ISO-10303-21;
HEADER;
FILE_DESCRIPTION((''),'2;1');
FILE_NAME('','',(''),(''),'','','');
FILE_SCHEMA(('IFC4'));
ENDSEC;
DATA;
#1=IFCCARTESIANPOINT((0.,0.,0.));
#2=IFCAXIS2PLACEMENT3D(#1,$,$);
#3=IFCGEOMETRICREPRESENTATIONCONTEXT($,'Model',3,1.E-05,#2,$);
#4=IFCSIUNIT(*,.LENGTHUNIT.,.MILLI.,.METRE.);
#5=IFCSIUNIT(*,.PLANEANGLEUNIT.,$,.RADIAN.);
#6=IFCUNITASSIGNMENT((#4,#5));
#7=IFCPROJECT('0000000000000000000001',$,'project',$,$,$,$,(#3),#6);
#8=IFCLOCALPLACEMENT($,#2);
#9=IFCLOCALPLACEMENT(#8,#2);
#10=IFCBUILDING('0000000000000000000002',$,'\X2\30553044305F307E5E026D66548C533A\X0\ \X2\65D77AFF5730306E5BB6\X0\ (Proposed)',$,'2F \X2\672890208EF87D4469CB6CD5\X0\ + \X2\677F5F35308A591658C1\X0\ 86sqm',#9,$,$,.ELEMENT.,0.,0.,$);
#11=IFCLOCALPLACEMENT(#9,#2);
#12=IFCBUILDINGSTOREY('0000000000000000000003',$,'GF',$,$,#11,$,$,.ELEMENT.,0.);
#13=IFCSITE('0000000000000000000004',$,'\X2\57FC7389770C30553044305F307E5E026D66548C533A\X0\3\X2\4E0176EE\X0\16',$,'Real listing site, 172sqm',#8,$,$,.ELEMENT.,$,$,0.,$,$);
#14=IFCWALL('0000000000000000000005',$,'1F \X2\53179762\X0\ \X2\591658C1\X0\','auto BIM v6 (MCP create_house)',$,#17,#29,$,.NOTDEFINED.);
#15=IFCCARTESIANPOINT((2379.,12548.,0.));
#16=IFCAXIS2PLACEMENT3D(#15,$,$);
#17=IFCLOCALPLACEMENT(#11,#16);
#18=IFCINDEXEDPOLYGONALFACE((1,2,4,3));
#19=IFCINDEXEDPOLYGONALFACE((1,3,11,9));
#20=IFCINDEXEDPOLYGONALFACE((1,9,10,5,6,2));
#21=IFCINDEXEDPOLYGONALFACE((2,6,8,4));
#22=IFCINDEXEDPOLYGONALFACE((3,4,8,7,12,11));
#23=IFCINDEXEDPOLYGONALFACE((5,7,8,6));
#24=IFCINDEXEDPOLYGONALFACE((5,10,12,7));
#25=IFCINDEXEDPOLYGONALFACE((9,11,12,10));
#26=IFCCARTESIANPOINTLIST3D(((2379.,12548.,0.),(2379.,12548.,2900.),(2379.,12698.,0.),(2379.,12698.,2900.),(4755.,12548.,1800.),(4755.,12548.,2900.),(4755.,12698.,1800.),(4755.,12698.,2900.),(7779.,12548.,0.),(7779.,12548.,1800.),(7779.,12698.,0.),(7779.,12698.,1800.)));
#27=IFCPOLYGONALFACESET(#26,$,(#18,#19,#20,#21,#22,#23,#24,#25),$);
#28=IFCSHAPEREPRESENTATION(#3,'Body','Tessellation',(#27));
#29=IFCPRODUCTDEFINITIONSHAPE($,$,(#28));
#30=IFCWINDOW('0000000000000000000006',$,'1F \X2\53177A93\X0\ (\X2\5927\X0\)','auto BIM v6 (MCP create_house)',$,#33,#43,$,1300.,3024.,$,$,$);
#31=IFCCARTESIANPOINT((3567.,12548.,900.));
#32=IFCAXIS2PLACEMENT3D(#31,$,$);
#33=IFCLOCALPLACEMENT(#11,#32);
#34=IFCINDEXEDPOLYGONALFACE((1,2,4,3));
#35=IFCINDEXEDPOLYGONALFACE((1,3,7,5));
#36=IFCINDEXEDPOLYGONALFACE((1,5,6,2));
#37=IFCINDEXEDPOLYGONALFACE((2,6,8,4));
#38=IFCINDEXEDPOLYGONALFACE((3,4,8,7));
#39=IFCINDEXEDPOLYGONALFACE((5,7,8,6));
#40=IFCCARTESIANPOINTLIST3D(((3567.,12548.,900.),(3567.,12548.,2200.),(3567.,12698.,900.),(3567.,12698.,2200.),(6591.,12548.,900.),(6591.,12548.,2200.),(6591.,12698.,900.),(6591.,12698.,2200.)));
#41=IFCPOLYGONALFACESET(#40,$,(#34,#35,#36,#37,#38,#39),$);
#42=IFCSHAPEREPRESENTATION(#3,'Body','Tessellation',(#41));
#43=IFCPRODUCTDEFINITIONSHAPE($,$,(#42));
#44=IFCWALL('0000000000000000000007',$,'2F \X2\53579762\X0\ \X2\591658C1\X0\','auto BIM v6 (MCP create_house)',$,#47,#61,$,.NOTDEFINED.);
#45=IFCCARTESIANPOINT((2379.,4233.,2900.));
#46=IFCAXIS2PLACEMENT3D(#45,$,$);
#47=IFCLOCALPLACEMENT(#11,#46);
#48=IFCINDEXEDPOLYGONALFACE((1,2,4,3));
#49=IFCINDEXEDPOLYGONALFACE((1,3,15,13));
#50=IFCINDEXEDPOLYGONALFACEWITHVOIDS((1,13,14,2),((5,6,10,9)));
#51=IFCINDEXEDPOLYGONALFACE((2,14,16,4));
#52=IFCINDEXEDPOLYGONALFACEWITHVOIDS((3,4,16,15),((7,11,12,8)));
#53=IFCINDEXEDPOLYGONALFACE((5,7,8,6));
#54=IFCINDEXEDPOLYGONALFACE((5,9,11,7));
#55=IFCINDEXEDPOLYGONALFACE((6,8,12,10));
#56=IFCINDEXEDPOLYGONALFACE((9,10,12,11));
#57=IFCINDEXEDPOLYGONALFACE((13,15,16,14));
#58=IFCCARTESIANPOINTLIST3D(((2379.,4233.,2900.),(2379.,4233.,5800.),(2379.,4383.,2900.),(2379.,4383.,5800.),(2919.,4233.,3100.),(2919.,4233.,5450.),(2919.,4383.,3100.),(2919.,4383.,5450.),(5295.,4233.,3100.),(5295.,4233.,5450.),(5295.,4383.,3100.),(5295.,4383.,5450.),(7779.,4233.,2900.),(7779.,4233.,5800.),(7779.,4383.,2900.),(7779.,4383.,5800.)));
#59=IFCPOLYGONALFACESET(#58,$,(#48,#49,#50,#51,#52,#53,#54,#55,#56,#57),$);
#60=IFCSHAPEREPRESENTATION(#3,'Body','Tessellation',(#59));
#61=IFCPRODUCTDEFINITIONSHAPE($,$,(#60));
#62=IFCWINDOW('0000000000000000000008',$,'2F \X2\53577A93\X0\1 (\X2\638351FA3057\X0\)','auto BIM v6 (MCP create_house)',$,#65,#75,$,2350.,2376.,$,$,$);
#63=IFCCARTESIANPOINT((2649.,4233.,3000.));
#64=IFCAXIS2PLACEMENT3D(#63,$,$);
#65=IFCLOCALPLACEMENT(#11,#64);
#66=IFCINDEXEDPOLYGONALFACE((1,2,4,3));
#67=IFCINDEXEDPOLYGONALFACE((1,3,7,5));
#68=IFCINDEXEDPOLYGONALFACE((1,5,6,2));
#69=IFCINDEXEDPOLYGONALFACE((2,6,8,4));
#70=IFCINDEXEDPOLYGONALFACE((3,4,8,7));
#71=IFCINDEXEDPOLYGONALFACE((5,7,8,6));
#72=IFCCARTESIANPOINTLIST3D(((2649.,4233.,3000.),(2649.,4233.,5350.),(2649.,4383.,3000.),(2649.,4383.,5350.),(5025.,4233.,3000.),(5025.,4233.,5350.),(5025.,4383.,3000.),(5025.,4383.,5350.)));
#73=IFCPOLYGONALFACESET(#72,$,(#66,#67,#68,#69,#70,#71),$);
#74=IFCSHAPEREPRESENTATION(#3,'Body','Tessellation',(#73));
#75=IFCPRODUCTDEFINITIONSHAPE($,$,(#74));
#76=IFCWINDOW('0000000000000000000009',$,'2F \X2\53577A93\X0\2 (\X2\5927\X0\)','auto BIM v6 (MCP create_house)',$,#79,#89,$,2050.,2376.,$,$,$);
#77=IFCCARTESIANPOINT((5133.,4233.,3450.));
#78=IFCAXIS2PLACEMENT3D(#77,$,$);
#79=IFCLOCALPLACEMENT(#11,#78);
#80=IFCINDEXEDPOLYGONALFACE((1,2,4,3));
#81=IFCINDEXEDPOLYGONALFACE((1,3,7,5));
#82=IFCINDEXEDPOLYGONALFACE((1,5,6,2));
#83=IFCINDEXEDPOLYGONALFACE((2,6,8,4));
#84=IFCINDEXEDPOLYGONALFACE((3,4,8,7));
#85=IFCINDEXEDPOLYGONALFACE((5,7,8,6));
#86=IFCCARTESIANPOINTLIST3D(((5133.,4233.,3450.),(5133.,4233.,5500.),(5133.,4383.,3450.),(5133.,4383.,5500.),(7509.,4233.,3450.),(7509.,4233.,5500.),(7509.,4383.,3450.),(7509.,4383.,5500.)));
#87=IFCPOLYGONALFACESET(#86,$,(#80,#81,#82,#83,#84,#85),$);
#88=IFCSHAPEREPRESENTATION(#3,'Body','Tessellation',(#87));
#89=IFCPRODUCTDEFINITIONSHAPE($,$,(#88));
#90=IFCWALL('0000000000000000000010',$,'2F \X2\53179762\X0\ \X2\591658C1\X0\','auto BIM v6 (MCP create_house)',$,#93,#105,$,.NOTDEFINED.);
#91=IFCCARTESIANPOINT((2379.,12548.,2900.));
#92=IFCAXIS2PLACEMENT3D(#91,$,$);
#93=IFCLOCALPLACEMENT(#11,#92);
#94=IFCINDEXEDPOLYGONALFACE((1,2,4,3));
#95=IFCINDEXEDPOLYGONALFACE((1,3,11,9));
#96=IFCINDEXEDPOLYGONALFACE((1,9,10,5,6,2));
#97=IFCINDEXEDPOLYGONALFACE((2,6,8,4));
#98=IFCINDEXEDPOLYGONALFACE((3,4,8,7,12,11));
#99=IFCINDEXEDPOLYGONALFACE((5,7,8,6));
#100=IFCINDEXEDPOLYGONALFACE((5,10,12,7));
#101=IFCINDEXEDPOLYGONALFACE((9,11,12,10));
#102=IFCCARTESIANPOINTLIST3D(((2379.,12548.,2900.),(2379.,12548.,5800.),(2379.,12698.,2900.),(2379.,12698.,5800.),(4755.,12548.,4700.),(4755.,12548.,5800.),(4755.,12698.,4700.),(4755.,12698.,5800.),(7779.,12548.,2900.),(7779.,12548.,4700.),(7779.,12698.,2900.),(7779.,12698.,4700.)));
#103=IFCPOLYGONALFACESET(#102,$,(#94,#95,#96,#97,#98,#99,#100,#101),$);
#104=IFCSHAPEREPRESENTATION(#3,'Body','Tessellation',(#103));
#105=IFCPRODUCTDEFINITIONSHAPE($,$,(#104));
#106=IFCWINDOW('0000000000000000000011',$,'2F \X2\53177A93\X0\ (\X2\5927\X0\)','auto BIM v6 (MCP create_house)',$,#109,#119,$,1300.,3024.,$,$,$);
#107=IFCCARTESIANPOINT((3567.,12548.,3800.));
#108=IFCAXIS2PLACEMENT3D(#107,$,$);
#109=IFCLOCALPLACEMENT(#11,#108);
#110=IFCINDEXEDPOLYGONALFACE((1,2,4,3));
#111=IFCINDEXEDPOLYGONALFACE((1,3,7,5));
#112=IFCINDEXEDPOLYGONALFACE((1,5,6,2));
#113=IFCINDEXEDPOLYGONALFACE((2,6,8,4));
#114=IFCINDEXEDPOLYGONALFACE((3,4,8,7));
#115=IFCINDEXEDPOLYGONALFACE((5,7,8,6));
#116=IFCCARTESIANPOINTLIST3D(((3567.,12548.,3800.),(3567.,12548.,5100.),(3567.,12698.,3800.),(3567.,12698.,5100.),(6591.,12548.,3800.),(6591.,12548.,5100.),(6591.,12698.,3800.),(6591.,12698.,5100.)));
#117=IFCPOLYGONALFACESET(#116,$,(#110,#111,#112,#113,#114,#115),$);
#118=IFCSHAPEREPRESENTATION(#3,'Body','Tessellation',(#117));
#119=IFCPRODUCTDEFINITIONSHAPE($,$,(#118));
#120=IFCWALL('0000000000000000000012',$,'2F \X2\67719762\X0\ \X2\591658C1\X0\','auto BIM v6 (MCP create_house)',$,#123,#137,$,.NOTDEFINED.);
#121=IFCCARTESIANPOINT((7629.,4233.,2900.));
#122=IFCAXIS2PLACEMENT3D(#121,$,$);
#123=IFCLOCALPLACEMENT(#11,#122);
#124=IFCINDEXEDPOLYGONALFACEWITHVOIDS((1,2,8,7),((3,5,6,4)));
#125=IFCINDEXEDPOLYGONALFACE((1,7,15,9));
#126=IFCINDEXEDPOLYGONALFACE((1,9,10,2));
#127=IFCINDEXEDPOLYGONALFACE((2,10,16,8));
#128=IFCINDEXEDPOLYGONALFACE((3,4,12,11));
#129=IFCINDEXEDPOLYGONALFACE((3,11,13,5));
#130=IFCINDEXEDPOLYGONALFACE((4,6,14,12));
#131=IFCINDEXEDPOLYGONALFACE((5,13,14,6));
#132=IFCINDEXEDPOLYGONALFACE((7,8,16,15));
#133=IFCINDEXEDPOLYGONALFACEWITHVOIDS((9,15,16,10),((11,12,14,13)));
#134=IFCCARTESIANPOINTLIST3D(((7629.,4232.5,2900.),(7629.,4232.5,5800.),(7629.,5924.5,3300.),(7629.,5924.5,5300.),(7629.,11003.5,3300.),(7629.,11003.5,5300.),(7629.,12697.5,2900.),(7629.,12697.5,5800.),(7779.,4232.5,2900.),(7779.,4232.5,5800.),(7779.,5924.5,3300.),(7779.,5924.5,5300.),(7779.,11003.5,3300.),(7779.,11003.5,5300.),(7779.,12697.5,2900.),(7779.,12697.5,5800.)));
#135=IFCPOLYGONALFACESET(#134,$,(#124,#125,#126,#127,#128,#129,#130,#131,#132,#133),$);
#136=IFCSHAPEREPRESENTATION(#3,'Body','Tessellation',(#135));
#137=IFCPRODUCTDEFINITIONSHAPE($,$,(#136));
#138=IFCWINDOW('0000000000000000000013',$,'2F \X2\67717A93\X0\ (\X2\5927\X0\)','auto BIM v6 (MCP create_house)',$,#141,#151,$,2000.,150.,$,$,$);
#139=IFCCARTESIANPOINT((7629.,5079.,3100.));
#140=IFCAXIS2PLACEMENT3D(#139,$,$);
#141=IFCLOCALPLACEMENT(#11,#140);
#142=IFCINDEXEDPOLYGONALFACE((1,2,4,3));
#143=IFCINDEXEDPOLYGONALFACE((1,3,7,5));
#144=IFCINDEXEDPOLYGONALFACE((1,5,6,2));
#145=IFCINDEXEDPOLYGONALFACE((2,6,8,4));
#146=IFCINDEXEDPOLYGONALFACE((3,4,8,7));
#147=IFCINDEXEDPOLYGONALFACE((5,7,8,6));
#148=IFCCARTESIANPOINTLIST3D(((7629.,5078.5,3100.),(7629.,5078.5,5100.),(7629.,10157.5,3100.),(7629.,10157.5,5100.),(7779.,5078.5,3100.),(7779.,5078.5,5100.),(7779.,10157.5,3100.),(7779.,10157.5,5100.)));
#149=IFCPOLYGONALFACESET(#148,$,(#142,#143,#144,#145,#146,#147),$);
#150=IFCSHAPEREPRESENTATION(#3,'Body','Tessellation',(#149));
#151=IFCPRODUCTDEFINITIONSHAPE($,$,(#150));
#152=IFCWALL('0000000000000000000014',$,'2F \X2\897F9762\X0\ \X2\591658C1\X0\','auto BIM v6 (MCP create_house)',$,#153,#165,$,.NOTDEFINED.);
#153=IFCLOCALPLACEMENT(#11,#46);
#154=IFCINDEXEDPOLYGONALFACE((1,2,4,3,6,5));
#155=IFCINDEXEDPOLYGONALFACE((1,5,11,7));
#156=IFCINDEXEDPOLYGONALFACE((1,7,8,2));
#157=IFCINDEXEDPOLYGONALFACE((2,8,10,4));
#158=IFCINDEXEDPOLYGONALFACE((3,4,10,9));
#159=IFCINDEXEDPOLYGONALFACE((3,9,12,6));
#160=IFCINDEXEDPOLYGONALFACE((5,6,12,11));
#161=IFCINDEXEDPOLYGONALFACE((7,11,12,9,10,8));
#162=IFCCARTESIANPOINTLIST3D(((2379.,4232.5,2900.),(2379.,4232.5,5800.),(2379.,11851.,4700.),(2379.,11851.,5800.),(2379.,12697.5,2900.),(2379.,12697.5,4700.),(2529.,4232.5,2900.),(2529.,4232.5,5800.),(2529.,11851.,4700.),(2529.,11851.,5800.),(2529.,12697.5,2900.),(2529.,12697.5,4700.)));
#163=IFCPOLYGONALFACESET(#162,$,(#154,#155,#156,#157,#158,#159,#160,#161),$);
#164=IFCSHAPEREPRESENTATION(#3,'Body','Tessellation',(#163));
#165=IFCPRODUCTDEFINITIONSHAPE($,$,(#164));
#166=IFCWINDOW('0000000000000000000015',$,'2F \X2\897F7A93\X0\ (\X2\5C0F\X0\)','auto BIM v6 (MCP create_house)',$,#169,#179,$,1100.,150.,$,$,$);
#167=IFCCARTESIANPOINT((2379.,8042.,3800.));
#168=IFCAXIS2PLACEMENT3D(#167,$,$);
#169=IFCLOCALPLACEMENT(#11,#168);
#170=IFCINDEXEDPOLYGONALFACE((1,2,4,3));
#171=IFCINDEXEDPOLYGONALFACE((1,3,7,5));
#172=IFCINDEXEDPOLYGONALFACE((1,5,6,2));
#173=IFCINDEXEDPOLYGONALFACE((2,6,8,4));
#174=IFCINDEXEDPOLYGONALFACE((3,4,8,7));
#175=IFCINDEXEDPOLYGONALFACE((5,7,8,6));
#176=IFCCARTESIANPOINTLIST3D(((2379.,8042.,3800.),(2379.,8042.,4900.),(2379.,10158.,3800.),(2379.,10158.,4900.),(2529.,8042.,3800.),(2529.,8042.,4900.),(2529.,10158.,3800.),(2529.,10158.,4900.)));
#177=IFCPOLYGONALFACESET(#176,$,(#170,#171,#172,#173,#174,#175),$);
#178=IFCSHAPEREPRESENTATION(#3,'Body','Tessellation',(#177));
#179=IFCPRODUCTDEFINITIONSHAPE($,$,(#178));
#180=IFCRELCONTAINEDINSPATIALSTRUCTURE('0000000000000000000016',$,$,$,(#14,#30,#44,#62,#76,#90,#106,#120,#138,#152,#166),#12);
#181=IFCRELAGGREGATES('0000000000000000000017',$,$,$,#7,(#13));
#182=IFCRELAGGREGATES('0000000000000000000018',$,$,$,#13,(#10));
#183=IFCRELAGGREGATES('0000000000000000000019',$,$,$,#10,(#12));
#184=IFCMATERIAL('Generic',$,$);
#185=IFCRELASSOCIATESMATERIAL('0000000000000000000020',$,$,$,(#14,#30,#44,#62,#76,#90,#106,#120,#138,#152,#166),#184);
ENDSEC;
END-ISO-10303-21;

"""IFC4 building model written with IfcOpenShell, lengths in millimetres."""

from ifc_helpers import new_model, si_unit, frame, frame_2d, origin, place, context, project, spatial, rectangle, extrude, material, element, fill, save


model = new_model("IFC4")

# Units and contexts
model_context = context("Model", 3, precision=1e-05, world=origin())
ifc_project = project(units=[si_unit("LENGTHUNIT", "METRE", prefix="MILLI"), si_unit("PLANEANGLEUNIT", "RADIAN")], contexts=[model_context])

# Site, building, storey
site_placement = place(None, origin())
site = spatial("IfcSite", under=ifc_project, at=site_placement, Name="埼玉県さいたま市浦和区3丁目16", ObjectType="Real listing site, 172sqm", CompositionType="ELEMENT", RefElevation=0.0)
building_placement = place(site_placement, origin())
building = spatial("IfcBuilding", under=site, at=building_placement, Name="さいたま市浦和区 旗竿地の家 (Proposed)", ObjectType="2F 木造軸組構法 + 板張り外壁 86sqm", CompositionType="ELEMENT", ElevationOfRefHeight=0.0, ElevationOfTerrain=0.0)
storey_placement = place(building_placement, origin())
storey = spatial("IfcBuildingStorey", under=building, at=storey_placement, Name="GF", CompositionType="ELEMENT", Elevation=0.0)

# Wall, opening, window
ifc_material = material(Name="Generic")
wall_1_placement = place(storey_placement, frame((2379.0, 12548.0, 0.0)))
wall_1 = element("IfcWall", 1, at=wall_1_placement, inside=storey, material=ifc_material, Name="1F 北面 外壁", Description="auto BIM v6 (MCP create_house)", PredefinedType="NOTDEFINED", context=model_context, shape_type="SweptSolid", body=[
    extrude(rectangle(XDim=5400.0, YDim=150.0, at=frame_2d((2700.0, 75.0))), frame((2379.0, 12548.0, 0.0)), (0.0, 0.0, 1.0), 2900.0),
])
opening_1_placement = place(storey_placement, frame((3567.0, 12548.0, 900.0)))
opening_1 = element("IfcOpeningElement", 2, at=opening_1_placement, cuts=wall_1, PredefinedType="NOTDEFINED", context=model_context, shape_type="SweptSolid", body=[
    extrude(rectangle(XDim=3024.0, YDim=150.0, at=frame_2d((1512.0, 75.0))), frame((3567.0, 12548.0, 900.0)), (0.0, 0.0, 1.0), 1300.0),
])
window_1_placement = place(storey_placement, frame((3567.0, 12548.0, 900.0)))
window_1 = element("IfcWindow", 3, at=window_1_placement, inside=storey, material=ifc_material, Name="1F 北窓 (大)", Description="auto BIM v6 (MCP create_house)", OverallHeight=1300.0, OverallWidth=3024.0, context=model_context, shape_type="SweptSolid", body=[
    extrude(rectangle(XDim=3024.0, YDim=150.0, at=frame_2d((1512.0, 75.0))), frame((3567.0, 12548.0, 900.0)), (0.0, 0.0, 1.0), 1300.0),
])
fill(opening_1, window_1)

# Wall, openings, windows
wall_2_placement = place(storey_placement, frame((2379.0, 4233.0, 2900.0)))
wall_2 = element("IfcWall", 4, at=wall_2_placement, inside=storey, material=ifc_material, Name="2F 南面 外壁", Description="auto BIM v6 (MCP create_house)", PredefinedType="NOTDEFINED", context=model_context, shape_type="SweptSolid", body=[
    extrude(rectangle(XDim=5400.0, YDim=150.0, at=frame_2d((2700.0, 75.0))), frame((2379.0, 4233.0, 2900.0)), (0.0, 0.0, 1.0), 2900.0),
])
opening_2_placement = place(storey_placement, frame((2649.0, 4233.0, 3000.0)))
opening_2 = element("IfcOpeningElement", 5, at=opening_2_placement, cuts=wall_2, PredefinedType="NOTDEFINED", context=model_context, shape_type="SweptSolid", body=[
    extrude(rectangle(XDim=2376.0, YDim=150.0, at=frame_2d((1188.0, 75.0))), frame((2649.0, 4233.0, 3000.0)), (0.0, 0.0, 1.0), 2350.0),
])
opening_3_placement = place(storey_placement, frame((5133.0, 4233.0, 3450.0)))
opening_3 = element("IfcOpeningElement", 6, at=opening_3_placement, cuts=wall_2, PredefinedType="NOTDEFINED", context=model_context, shape_type="SweptSolid", body=[
    extrude(rectangle(XDim=2376.0, YDim=150.0, at=frame_2d((1188.0, 75.0))), frame((5133.0, 4233.0, 3450.0)), (0.0, 0.0, 1.0), 2050.0),
])
window_2_placement = place(storey_placement, frame((2649.0, 4233.0, 3000.0)))
window_2 = element("IfcWindow", 7, at=window_2_placement, inside=storey, material=ifc_material, Name="2F 南窓1 (掃出し)", Description="auto BIM v6 (MCP create_house)", OverallHeight=2350.0, OverallWidth=2376.0, context=model_context, shape_type="SweptSolid", body=[
    extrude(rectangle(XDim=2376.0, YDim=150.0, at=frame_2d((1188.0, 75.0))), frame((2649.0, 4233.0, 3000.0)), (0.0, 0.0, 1.0), 2350.0),
])
fill(opening_2, window_2)
window_3_placement = place(storey_placement, frame((5133.0, 4233.0, 3450.0)))
window_3 = element("IfcWindow", 8, at=window_3_placement, inside=storey, material=ifc_material, Name="2F 南窓2 (大)", Description="auto BIM v6 (MCP create_house)", OverallHeight=2050.0, OverallWidth=2376.0, context=model_context, shape_type="SweptSolid", body=[
    extrude(rectangle(XDim=2376.0, YDim=150.0, at=frame_2d((1188.0, 75.0))), frame((5133.0, 4233.0, 3450.0)), (0.0, 0.0, 1.0), 2050.0),
])
fill(opening_3, window_3)

# Walls, openings, windows
wall_3_placement = place(storey_placement, frame((2379.0, 12548.0, 2900.0)))
wall_3 = element("IfcWall", 9, at=wall_3_placement, inside=storey, material=ifc_material, Name="2F 北面 外壁", Description="auto BIM v6 (MCP create_house)", PredefinedType="NOTDEFINED", context=model_context, shape_type="SweptSolid", body=[
    extrude(rectangle(XDim=5400.0, YDim=150.0, at=frame_2d((2700.0, 75.0))), frame((2379.0, 12548.0, 2900.0)), (0.0, 0.0, 1.0), 2900.0),
])
opening_4_placement = place(storey_placement, frame((3567.0, 12548.0, 3800.0)))
opening_4 = element("IfcOpeningElement", 10, at=opening_4_placement, cuts=wall_3, PredefinedType="NOTDEFINED", context=model_context, shape_type="SweptSolid", body=[
    extrude(rectangle(XDim=3024.0, YDim=150.0, at=frame_2d((1512.0, 75.0))), frame((3567.0, 12548.0, 3800.0)), (0.0, 0.0, 1.0), 1300.0),
])
window_4_placement = place(storey_placement, frame((3567.0, 12548.0, 3800.0)))
window_4 = element("IfcWindow", 11, at=window_4_placement, inside=storey, material=ifc_material, Name="2F 北窓 (大)", Description="auto BIM v6 (MCP create_house)", OverallHeight=1300.0, OverallWidth=3024.0, context=model_context, shape_type="SweptSolid", body=[
    extrude(rectangle(XDim=3024.0, YDim=150.0, at=frame_2d((1512.0, 75.0))), frame((3567.0, 12548.0, 3800.0)), (0.0, 0.0, 1.0), 1300.0),
])
fill(opening_4, window_4)
wall_4_placement = place(storey_placement, frame((7629.0, 4233.0, 2900.0)))
wall_4 = element("IfcWall", 12, at=wall_4_placement, inside=storey, material=ifc_material, Name="2F 東面 外壁", Description="auto BIM v6 (MCP create_house)", PredefinedType="NOTDEFINED", context=model_context, shape_type="SweptSolid", body=[
    extrude(rectangle(XDim=150.0, YDim=8465.0, at=frame_2d((75.0, 4232.0))), frame((7629.0, 4233.0, 2900.0)), (0.0, 0.0, 1.0), 2900.0),
])
opening_5_placement = place(storey_placement, frame((7629.0, 5079.0, 3100.0)))
opening_5 = element("IfcOpeningElement", 13, at=opening_5_placement, cuts=wall_4, PredefinedType="NOTDEFINED", context=model_context, shape_type="SweptSolid", body=[
    extrude(rectangle(XDim=150.0, YDim=5079.0, at=frame_2d((75.0, 2539.0))), frame((7629.0, 5079.0, 3100.0)), (0.0, 0.0, 1.0), 2000.0),
])
window_5_placement = place(storey_placement, frame((7629.0, 5079.0, 3100.0)))
window_5 = element("IfcWindow", 14, at=window_5_placement, inside=storey, material=ifc_material, Name="2F 東窓 (大)", Description="auto BIM v6 (MCP create_house)", OverallHeight=2000.0, OverallWidth=150.0, context=model_context, shape_type="SweptSolid", body=[
    extrude(rectangle(XDim=150.0, YDim=5079.0, at=frame_2d((75.0, 2539.0))), frame((7629.0, 5079.0, 3100.0)), (0.0, 0.0, 1.0), 2000.0),
])
fill(opening_5, window_5)
wall_5_placement = place(storey_placement, frame((2379.0, 4233.0, 2900.0)))
wall_5 = element("IfcWall", 15, at=wall_5_placement, inside=storey, material=ifc_material, Name="2F 西面 外壁", Description="auto BIM v6 (MCP create_house)", PredefinedType="NOTDEFINED", context=model_context, shape_type="SweptSolid", body=[
    extrude(rectangle(XDim=150.0, YDim=8465.0, at=frame_2d((75.0, 4232.0))), frame((2379.0, 4233.0, 2900.0)), (0.0, 0.0, 1.0), 2900.0),
])
opening_6_placement = place(storey_placement, frame((2379.0, 8042.0, 3800.0)))
opening_6 = element("IfcOpeningElement", 16, at=opening_6_placement, cuts=wall_5, PredefinedType="NOTDEFINED", context=model_context, shape_type="SweptSolid", body=[
    extrude(rectangle(XDim=150.0, YDim=2116.0, at=frame_2d((75.0, 1058.0))), frame((2379.0, 8042.0, 3800.0)), (0.0, 0.0, 1.0), 1100.0),
])
window_6_placement = place(storey_placement, frame((2379.0, 8042.0, 3800.0)))
window_6 = element("IfcWindow", 17, at=window_6_placement, inside=storey, material=ifc_material, Name="2F 西窓 (小)", Description="auto BIM v6 (MCP create_house)", OverallHeight=1100.0, OverallWidth=150.0, context=model_context, shape_type="SweptSolid", body=[
    extrude(rectangle(XDim=150.0, YDim=2116.0, at=frame_2d((75.0, 1058.0))), frame((2379.0, 8042.0, 3800.0)), (0.0, 0.0, 1.0), 1100.0),
])
fill(opening_6, window_6)

save(model, "model.ifc")
